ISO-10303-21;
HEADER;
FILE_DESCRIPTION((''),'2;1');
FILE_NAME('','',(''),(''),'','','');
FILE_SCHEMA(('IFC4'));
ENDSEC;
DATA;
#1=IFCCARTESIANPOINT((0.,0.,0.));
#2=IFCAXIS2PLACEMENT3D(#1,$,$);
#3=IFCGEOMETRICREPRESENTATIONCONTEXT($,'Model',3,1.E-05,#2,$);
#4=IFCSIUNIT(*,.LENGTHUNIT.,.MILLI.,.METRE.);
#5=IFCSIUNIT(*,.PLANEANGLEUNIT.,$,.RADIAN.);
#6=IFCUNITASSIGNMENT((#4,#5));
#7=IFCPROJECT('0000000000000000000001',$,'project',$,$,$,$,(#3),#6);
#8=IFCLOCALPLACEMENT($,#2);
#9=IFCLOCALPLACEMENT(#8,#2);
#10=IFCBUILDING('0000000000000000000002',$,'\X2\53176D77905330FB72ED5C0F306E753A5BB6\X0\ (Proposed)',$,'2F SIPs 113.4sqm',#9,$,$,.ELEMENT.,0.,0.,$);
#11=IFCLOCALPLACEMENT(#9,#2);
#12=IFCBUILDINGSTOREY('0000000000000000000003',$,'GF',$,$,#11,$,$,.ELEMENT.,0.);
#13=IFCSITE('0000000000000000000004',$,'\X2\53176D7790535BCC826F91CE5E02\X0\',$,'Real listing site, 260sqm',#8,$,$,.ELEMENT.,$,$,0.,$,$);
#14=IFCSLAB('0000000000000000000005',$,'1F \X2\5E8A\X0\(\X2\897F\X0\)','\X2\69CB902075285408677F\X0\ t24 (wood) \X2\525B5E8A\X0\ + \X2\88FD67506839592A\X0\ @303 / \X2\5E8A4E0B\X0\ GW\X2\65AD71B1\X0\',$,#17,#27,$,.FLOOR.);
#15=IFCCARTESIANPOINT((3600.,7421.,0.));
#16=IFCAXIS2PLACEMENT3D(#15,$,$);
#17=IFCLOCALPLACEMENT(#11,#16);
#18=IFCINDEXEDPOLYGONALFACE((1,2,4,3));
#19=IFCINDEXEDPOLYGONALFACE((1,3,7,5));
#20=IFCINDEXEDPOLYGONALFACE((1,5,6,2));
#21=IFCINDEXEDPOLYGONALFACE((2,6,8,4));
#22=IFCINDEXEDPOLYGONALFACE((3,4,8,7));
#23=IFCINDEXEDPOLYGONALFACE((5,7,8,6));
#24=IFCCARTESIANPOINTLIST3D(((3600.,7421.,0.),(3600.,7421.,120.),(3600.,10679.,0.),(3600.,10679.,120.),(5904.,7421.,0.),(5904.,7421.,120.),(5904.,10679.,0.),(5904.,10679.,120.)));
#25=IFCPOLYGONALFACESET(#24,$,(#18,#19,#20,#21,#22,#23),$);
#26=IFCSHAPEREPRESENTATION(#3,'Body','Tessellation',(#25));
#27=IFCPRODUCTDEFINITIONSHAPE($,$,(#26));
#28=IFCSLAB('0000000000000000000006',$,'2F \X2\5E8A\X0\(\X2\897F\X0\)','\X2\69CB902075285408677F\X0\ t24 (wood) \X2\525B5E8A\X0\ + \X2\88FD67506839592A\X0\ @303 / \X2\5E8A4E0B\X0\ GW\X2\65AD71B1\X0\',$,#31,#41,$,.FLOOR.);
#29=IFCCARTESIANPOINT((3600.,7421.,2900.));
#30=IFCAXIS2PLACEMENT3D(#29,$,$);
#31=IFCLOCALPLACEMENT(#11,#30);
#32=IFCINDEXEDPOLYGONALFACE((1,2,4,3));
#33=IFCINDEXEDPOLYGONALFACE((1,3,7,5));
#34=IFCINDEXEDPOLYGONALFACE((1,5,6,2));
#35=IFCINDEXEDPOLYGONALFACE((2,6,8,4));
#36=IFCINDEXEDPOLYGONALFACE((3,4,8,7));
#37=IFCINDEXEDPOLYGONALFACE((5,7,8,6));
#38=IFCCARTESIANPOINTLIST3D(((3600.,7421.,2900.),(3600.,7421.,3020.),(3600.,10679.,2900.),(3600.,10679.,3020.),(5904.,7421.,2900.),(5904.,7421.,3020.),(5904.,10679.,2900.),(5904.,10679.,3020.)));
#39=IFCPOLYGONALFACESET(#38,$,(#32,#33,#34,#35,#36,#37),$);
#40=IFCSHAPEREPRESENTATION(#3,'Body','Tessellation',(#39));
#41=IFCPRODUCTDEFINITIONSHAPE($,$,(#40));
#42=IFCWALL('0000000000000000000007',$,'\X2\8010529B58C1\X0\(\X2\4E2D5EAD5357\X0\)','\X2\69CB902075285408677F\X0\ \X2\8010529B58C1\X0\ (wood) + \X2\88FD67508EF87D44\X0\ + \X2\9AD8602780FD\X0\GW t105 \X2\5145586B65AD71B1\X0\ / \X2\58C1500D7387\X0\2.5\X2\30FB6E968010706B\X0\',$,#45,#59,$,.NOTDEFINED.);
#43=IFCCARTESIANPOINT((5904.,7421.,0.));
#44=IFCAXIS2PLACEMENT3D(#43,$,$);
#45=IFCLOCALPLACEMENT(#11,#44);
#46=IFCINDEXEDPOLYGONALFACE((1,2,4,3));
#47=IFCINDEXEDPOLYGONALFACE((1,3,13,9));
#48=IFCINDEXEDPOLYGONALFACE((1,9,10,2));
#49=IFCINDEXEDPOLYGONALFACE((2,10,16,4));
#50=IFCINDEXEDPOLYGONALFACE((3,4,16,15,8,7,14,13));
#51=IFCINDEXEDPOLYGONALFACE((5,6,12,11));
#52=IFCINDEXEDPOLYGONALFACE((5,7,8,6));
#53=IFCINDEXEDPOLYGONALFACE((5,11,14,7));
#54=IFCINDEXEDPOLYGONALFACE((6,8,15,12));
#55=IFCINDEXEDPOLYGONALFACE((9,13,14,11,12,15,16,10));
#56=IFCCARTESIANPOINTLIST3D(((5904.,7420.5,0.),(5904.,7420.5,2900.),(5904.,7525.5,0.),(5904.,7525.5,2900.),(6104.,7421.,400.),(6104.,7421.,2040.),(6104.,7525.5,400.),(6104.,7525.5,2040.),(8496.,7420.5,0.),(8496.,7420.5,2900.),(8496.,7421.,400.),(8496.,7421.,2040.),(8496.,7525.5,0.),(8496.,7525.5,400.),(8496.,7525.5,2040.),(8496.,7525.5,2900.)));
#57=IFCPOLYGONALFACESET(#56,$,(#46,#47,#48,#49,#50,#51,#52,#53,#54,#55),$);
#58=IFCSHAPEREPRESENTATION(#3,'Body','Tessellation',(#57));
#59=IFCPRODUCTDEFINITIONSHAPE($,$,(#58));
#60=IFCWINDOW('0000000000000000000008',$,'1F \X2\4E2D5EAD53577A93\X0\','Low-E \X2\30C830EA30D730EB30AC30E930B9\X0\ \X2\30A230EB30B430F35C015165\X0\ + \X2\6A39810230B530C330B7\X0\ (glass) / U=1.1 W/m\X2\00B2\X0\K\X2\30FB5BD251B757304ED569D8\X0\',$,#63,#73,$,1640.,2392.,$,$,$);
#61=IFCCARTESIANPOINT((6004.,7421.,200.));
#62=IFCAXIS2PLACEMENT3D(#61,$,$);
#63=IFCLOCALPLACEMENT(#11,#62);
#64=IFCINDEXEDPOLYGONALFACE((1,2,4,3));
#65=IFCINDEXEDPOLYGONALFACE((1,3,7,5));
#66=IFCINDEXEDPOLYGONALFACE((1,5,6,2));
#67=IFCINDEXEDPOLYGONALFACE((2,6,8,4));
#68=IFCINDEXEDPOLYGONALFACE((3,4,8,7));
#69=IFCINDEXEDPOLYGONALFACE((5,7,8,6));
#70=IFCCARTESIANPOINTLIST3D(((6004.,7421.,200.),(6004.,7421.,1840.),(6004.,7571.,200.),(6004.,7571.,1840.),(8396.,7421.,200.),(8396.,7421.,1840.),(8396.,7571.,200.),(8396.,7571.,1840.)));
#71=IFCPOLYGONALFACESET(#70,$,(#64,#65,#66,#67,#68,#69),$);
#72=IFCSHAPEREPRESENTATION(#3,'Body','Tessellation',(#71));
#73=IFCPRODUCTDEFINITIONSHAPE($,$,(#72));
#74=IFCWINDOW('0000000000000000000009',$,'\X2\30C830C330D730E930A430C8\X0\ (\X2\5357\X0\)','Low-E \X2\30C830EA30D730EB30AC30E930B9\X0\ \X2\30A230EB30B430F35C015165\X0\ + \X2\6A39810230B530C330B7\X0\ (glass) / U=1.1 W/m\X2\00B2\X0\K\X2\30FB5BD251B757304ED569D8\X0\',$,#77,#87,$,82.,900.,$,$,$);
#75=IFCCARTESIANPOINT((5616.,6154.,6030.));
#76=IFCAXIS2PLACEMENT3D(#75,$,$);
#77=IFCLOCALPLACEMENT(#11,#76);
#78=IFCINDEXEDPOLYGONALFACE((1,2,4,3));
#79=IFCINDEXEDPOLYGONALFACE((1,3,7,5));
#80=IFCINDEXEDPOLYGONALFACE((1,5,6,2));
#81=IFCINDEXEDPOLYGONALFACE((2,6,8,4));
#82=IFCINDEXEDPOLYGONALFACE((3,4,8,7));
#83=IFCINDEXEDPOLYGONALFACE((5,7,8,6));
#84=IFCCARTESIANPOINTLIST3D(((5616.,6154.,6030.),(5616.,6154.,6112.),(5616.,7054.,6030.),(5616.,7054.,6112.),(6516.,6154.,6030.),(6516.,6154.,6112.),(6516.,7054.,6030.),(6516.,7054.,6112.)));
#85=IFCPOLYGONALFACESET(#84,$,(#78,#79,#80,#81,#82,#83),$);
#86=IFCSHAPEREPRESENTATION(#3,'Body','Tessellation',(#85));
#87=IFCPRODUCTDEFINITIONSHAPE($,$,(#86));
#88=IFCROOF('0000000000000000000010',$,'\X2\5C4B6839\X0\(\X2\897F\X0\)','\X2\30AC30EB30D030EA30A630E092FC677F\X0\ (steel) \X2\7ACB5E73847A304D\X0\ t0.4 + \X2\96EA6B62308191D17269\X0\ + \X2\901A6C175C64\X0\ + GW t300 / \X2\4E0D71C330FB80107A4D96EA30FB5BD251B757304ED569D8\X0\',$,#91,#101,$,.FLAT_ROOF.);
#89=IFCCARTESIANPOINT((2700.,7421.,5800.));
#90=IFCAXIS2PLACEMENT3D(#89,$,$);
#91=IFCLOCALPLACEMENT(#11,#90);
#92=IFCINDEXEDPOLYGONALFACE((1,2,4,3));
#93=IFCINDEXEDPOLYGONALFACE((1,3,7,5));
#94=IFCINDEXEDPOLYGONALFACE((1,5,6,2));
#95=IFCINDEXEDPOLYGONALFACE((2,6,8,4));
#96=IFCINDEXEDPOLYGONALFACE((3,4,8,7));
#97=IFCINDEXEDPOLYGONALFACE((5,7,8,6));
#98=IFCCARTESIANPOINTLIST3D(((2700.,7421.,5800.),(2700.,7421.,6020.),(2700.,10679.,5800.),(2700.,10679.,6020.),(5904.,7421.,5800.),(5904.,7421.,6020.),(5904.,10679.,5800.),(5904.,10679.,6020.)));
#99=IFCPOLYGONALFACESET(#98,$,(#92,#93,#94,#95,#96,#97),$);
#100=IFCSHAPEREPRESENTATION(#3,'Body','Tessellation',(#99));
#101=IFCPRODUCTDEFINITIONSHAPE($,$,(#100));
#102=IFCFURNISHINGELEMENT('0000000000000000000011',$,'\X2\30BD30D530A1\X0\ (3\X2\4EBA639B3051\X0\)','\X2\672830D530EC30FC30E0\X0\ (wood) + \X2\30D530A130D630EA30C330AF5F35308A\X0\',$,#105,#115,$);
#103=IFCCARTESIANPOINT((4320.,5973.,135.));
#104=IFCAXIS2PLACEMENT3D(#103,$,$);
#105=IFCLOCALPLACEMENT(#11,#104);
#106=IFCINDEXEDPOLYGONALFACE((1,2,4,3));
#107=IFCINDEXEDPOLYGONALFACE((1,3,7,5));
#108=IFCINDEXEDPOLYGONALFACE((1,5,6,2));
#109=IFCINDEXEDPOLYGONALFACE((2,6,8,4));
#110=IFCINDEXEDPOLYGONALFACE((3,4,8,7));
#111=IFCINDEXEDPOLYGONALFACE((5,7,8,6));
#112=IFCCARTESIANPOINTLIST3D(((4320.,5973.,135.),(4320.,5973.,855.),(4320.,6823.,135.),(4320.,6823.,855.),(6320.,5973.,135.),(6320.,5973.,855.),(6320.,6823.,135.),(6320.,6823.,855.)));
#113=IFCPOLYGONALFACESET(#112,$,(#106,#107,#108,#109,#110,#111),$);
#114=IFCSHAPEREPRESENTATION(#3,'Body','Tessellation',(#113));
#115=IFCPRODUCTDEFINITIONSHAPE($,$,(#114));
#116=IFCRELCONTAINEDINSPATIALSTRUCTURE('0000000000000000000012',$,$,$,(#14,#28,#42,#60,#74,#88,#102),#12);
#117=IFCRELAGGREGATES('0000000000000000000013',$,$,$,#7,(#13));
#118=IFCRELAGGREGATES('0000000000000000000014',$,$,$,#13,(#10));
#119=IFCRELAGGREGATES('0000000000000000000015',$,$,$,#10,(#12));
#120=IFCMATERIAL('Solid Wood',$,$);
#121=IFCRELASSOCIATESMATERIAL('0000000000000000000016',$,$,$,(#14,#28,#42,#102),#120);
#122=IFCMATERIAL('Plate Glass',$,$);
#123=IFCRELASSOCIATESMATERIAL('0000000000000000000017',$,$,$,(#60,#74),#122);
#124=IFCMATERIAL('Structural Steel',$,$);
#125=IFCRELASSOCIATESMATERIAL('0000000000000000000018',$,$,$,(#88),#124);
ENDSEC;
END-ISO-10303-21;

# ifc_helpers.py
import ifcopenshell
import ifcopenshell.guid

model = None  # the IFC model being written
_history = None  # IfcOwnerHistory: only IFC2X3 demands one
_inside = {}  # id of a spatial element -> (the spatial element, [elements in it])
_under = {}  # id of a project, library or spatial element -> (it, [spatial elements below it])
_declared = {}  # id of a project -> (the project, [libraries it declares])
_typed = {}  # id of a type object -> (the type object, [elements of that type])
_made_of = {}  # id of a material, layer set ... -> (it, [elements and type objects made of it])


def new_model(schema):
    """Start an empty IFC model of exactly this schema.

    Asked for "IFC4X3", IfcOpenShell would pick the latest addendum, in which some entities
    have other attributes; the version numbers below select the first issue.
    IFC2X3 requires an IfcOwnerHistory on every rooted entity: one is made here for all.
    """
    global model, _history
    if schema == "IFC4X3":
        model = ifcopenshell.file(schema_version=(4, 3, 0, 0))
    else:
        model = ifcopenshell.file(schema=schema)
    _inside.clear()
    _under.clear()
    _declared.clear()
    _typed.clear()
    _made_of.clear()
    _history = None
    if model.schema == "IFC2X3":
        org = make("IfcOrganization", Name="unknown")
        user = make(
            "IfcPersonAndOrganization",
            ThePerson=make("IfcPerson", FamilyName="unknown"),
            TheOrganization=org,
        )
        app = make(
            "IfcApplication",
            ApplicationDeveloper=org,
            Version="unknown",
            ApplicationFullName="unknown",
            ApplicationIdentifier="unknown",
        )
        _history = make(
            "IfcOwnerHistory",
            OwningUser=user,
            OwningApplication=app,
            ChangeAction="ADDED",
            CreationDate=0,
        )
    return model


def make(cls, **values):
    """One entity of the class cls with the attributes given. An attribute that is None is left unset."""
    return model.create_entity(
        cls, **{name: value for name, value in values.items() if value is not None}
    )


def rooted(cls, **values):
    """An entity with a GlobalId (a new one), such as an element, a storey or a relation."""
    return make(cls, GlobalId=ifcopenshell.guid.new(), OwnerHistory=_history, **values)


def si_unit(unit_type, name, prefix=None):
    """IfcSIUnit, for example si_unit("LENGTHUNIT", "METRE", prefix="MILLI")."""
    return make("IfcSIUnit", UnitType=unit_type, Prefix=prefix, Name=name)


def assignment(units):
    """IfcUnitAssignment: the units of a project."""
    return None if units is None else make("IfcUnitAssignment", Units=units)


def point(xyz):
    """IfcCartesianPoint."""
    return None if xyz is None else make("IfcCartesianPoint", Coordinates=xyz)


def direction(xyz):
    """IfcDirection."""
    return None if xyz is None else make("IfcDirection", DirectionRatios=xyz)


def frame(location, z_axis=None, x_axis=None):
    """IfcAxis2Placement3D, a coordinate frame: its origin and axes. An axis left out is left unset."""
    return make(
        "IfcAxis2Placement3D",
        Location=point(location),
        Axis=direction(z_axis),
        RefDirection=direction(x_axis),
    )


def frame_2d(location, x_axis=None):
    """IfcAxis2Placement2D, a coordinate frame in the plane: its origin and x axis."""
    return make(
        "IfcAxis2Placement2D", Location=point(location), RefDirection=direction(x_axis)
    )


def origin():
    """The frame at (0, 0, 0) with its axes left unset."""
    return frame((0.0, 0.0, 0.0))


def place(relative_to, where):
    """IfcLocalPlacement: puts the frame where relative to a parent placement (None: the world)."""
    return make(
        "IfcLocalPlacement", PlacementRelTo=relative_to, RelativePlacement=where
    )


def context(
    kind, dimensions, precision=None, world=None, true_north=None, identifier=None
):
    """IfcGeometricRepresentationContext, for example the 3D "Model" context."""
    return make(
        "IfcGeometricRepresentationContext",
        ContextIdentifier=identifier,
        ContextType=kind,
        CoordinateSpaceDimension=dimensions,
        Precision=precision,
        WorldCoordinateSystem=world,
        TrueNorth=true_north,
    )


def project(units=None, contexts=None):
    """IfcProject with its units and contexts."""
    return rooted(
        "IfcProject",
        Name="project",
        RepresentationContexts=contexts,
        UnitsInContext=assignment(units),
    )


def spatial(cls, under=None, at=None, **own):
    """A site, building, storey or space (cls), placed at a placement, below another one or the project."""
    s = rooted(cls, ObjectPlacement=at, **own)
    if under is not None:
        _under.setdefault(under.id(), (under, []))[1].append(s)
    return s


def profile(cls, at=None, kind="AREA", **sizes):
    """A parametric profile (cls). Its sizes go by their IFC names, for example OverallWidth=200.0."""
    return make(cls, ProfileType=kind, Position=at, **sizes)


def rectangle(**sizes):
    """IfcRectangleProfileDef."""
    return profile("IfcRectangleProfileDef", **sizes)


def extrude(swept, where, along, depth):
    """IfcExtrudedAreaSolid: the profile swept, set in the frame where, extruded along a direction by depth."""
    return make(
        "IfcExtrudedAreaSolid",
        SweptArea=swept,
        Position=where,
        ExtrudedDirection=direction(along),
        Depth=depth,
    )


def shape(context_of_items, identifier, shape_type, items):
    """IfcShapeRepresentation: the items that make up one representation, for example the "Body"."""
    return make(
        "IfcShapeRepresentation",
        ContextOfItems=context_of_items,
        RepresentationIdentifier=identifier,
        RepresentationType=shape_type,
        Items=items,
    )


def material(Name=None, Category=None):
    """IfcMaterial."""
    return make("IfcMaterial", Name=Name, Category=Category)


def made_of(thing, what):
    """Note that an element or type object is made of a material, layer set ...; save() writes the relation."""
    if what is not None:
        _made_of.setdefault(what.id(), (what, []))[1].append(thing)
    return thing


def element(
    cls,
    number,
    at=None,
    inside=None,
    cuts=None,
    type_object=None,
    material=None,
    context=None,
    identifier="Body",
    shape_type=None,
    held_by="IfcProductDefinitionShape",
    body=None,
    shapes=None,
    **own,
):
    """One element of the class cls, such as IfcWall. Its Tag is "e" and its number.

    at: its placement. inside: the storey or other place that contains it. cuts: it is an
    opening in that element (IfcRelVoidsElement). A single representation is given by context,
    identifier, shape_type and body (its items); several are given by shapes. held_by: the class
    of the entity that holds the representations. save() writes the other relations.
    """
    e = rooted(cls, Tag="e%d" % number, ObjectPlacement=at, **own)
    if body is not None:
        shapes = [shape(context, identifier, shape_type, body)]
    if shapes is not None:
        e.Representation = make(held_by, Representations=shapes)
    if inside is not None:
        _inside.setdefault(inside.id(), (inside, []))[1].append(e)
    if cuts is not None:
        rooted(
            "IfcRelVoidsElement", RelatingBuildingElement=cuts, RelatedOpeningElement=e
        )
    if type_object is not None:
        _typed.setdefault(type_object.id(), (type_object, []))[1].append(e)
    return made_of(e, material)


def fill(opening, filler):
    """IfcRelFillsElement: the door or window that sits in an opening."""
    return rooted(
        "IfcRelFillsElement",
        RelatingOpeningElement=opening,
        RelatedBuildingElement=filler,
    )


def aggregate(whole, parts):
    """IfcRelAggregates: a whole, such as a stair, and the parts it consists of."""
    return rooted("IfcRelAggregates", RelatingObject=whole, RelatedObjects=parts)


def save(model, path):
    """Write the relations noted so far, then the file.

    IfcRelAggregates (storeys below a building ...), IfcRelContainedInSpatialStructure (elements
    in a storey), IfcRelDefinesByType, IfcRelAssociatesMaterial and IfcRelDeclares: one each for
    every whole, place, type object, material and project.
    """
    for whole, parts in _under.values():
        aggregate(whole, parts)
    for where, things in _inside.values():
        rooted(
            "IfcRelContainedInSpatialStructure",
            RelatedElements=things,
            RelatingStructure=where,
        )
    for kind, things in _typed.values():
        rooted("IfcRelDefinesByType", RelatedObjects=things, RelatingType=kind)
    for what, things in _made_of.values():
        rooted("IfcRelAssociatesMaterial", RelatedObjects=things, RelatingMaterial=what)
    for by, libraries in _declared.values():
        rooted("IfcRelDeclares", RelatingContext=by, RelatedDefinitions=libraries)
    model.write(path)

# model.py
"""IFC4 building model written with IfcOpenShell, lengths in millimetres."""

from ifc_helpers import new_model, si_unit, frame, frame_2d, origin, place, context, project, spatial, rectangle, extrude, material, element, fill, save


model = new_model("IFC4")

# Units and contexts
model_context = context("Model", 3, precision=1e-05, world=origin())
ifc_project = project(units=[si_unit("LENGTHUNIT", "METRE", prefix="MILLI"), si_unit("PLANEANGLEUNIT", "RADIAN")], contexts=[model_context])

# Site, building, storey
site_placement = place(None, origin())
site = spatial("IfcSite", under=ifc_project, at=site_placement, Name="北海道富良野市", ObjectType="Real listing site, 260sqm", CompositionType="ELEMENT", RefElevation=0.0)
building_placement = place(site_placement, origin())
building = spatial("IfcBuilding", under=site, at=building_placement, Name="北海道・狭小の町家 (Proposed)", ObjectType="2F SIPs 113.4sqm", CompositionType="ELEMENT", ElevationOfRefHeight=0.0, ElevationOfTerrain=0.0)
storey_placement = place(building_placement, origin())
storey = spatial("IfcBuildingStorey", under=building, at=storey_placement, Name="GF", CompositionType="ELEMENT", Elevation=0.0)

# Shared definitions
ifc_material_1 = material(Name="Solid Wood")

# Slabs
slab_1_placement = place(storey_placement, frame((3600.0, 7421.0, 0.0)))
element("IfcSlab", 1, at=slab_1_placement, inside=storey, material=ifc_material_1, Name="1F 床(西)", Description="構造用合板 t24 (wood) 剛床 + 製材根太 @303 / 床下 GW断熱", PredefinedType="FLOOR", context=model_context, shape_type="SweptSolid", body=[
    extrude(rectangle(XDim=2304.0, YDim=3258.0, at=frame_2d((1152.0, 1629.0))), frame((3600.0, 7421.0, 0.0)), (0.0, 0.0, 1.0), 120.0),
])
slab_2_placement = place(storey_placement, frame((3600.0, 7421.0, 2900.0)))
element("IfcSlab", 2, at=slab_2_placement, inside=storey, material=ifc_material_1, Name="2F 床(西)", Description="構造用合板 t24 (wood) 剛床 + 製材根太 @303 / 床下 GW断熱", PredefinedType="FLOOR", context=model_context, shape_type="SweptSolid", body=[
    extrude(rectangle(XDim=2304.0, YDim=3258.0, at=frame_2d((1152.0, 1629.0))), frame((3600.0, 7421.0, 2900.0)), (0.0, 0.0, 1.0), 120.0),
])

# Wall, opening, window
wall_placement = place(storey_placement, frame((5904.0, 7421.0, 0.0)))
wall = element("IfcWall", 3, at=wall_placement, inside=storey, material=ifc_material_1, Name="耐力壁(中庭南)", Description="構造用合板 耐力壁 (wood) + 製材軸組 + 高性能GW t105 充填断熱 / 壁倍率2.5・準耐火", PredefinedType="NOTDEFINED", context=model_context, shape_type="SweptSolid", body=[
    extrude(rectangle(XDim=2592.0, YDim=105.0, at=frame_2d((1296.0, 52.0))), frame((5904.0, 7421.0, 0.0)), (0.0, 0.0, 1.0), 2900.0),
])
opening_placement = place(storey_placement, frame((6004.0, 7421.0, 200.0)))
opening = element("IfcOpeningElement", 4, at=opening_placement, cuts=wall, PredefinedType="NOTDEFINED", context=model_context, shape_type="SweptSolid", body=[
    extrude(rectangle(XDim=2392.0, YDim=150.0, at=frame_2d((1196.0, 75.0))), frame((6004.0, 7421.0, 200.0)), (0.0, 0.0, 1.0), 1640.0),
])
ifc_material_2 = material(Name="Plate Glass")
window_1_placement = place(storey_placement, frame((6004.0, 7421.0, 200.0)))
window_1 = element("IfcWindow", 5, at=window_1_placement, inside=storey, material=ifc_material_2, Name="1F 中庭南窓", Description="Low-E トリプルガラス アルゴン封入 + 樹脂サッシ (glass) / U=1.1 W/m²K・寒冷地仕様", OverallHeight=1640.0, OverallWidth=2392.0, context=model_context, shape_type="SweptSolid", body=[
    extrude(rectangle(XDim=2392.0, YDim=150.0, at=frame_2d((1196.0, 75.0))), frame((6004.0, 7421.0, 200.0)), (0.0, 0.0, 1.0), 1640.0),
])
fill(opening, window_1)

# Window
window_2_placement = place(storey_placement, frame((5616.0, 6154.0, 6030.0)))
element("IfcWindow", 6, at=window_2_placement, inside=storey, material=ifc_material_2, Name="トップライト (南)", Description="Low-E トリプルガラス アルゴン封入 + 樹脂サッシ (glass) / U=1.1 W/m²K・寒冷地仕様", OverallHeight=82.0, OverallWidth=900.0, context=model_context, shape_type="SweptSolid", body=[
    extrude(rectangle(XDim=900.0, YDim=900.0, at=frame_2d((450.0, 450.0))), frame((5616.0, 6154.0, 6030.0)), (0.0, 0.0, 1.0), 82.0),
])

# Roof
ifc_material_3 = material(Name="Structural Steel")
for number, where, name in (
    (7, (2700.0, 7421.0, 5800.0), "屋根(西)"),
):
    element("IfcRoof", number, at=place(storey_placement, frame(where)), inside=storey, material=ifc_material_3, Name=name, Description="ガルバリウム鋼板 (steel) 立平葺き t0.4 + 雪止め金物 + 通気層 + GW t300 / 不燃・耐積雪・寒冷地仕様", PredefinedType="FLAT_ROOF", context=model_context, shape_type="SweptSolid", body=[
        extrude(rectangle(XDim=3204.0, YDim=3258.0, at=frame_2d((1602.0, 1629.0))), frame((2700.0, 7421.0, 5800.0)), (0.0, 0.0, 1.0), 220.0),
    ])

# Furnishing element
furnishing_placement = place(storey_placement, frame((4320.0, 5973.0, 135.0)))
element("IfcFurnishingElement", 8, at=furnishing_placement, inside=storey, material=ifc_material_1, Name="ソファ (3人掛け)", Description="木フレーム (wood) + ファブリック張り", context=model_context, shape_type="SweptSolid", body=[
    extrude(rectangle(XDim=2000.0, YDim=850.0, at=frame_2d((1000.0, 425.0))), frame((4320.0, 5973.0, 135.0)), (0.0, 0.0, 1.0), 720.0),
])

save(model, "model.ifc")
